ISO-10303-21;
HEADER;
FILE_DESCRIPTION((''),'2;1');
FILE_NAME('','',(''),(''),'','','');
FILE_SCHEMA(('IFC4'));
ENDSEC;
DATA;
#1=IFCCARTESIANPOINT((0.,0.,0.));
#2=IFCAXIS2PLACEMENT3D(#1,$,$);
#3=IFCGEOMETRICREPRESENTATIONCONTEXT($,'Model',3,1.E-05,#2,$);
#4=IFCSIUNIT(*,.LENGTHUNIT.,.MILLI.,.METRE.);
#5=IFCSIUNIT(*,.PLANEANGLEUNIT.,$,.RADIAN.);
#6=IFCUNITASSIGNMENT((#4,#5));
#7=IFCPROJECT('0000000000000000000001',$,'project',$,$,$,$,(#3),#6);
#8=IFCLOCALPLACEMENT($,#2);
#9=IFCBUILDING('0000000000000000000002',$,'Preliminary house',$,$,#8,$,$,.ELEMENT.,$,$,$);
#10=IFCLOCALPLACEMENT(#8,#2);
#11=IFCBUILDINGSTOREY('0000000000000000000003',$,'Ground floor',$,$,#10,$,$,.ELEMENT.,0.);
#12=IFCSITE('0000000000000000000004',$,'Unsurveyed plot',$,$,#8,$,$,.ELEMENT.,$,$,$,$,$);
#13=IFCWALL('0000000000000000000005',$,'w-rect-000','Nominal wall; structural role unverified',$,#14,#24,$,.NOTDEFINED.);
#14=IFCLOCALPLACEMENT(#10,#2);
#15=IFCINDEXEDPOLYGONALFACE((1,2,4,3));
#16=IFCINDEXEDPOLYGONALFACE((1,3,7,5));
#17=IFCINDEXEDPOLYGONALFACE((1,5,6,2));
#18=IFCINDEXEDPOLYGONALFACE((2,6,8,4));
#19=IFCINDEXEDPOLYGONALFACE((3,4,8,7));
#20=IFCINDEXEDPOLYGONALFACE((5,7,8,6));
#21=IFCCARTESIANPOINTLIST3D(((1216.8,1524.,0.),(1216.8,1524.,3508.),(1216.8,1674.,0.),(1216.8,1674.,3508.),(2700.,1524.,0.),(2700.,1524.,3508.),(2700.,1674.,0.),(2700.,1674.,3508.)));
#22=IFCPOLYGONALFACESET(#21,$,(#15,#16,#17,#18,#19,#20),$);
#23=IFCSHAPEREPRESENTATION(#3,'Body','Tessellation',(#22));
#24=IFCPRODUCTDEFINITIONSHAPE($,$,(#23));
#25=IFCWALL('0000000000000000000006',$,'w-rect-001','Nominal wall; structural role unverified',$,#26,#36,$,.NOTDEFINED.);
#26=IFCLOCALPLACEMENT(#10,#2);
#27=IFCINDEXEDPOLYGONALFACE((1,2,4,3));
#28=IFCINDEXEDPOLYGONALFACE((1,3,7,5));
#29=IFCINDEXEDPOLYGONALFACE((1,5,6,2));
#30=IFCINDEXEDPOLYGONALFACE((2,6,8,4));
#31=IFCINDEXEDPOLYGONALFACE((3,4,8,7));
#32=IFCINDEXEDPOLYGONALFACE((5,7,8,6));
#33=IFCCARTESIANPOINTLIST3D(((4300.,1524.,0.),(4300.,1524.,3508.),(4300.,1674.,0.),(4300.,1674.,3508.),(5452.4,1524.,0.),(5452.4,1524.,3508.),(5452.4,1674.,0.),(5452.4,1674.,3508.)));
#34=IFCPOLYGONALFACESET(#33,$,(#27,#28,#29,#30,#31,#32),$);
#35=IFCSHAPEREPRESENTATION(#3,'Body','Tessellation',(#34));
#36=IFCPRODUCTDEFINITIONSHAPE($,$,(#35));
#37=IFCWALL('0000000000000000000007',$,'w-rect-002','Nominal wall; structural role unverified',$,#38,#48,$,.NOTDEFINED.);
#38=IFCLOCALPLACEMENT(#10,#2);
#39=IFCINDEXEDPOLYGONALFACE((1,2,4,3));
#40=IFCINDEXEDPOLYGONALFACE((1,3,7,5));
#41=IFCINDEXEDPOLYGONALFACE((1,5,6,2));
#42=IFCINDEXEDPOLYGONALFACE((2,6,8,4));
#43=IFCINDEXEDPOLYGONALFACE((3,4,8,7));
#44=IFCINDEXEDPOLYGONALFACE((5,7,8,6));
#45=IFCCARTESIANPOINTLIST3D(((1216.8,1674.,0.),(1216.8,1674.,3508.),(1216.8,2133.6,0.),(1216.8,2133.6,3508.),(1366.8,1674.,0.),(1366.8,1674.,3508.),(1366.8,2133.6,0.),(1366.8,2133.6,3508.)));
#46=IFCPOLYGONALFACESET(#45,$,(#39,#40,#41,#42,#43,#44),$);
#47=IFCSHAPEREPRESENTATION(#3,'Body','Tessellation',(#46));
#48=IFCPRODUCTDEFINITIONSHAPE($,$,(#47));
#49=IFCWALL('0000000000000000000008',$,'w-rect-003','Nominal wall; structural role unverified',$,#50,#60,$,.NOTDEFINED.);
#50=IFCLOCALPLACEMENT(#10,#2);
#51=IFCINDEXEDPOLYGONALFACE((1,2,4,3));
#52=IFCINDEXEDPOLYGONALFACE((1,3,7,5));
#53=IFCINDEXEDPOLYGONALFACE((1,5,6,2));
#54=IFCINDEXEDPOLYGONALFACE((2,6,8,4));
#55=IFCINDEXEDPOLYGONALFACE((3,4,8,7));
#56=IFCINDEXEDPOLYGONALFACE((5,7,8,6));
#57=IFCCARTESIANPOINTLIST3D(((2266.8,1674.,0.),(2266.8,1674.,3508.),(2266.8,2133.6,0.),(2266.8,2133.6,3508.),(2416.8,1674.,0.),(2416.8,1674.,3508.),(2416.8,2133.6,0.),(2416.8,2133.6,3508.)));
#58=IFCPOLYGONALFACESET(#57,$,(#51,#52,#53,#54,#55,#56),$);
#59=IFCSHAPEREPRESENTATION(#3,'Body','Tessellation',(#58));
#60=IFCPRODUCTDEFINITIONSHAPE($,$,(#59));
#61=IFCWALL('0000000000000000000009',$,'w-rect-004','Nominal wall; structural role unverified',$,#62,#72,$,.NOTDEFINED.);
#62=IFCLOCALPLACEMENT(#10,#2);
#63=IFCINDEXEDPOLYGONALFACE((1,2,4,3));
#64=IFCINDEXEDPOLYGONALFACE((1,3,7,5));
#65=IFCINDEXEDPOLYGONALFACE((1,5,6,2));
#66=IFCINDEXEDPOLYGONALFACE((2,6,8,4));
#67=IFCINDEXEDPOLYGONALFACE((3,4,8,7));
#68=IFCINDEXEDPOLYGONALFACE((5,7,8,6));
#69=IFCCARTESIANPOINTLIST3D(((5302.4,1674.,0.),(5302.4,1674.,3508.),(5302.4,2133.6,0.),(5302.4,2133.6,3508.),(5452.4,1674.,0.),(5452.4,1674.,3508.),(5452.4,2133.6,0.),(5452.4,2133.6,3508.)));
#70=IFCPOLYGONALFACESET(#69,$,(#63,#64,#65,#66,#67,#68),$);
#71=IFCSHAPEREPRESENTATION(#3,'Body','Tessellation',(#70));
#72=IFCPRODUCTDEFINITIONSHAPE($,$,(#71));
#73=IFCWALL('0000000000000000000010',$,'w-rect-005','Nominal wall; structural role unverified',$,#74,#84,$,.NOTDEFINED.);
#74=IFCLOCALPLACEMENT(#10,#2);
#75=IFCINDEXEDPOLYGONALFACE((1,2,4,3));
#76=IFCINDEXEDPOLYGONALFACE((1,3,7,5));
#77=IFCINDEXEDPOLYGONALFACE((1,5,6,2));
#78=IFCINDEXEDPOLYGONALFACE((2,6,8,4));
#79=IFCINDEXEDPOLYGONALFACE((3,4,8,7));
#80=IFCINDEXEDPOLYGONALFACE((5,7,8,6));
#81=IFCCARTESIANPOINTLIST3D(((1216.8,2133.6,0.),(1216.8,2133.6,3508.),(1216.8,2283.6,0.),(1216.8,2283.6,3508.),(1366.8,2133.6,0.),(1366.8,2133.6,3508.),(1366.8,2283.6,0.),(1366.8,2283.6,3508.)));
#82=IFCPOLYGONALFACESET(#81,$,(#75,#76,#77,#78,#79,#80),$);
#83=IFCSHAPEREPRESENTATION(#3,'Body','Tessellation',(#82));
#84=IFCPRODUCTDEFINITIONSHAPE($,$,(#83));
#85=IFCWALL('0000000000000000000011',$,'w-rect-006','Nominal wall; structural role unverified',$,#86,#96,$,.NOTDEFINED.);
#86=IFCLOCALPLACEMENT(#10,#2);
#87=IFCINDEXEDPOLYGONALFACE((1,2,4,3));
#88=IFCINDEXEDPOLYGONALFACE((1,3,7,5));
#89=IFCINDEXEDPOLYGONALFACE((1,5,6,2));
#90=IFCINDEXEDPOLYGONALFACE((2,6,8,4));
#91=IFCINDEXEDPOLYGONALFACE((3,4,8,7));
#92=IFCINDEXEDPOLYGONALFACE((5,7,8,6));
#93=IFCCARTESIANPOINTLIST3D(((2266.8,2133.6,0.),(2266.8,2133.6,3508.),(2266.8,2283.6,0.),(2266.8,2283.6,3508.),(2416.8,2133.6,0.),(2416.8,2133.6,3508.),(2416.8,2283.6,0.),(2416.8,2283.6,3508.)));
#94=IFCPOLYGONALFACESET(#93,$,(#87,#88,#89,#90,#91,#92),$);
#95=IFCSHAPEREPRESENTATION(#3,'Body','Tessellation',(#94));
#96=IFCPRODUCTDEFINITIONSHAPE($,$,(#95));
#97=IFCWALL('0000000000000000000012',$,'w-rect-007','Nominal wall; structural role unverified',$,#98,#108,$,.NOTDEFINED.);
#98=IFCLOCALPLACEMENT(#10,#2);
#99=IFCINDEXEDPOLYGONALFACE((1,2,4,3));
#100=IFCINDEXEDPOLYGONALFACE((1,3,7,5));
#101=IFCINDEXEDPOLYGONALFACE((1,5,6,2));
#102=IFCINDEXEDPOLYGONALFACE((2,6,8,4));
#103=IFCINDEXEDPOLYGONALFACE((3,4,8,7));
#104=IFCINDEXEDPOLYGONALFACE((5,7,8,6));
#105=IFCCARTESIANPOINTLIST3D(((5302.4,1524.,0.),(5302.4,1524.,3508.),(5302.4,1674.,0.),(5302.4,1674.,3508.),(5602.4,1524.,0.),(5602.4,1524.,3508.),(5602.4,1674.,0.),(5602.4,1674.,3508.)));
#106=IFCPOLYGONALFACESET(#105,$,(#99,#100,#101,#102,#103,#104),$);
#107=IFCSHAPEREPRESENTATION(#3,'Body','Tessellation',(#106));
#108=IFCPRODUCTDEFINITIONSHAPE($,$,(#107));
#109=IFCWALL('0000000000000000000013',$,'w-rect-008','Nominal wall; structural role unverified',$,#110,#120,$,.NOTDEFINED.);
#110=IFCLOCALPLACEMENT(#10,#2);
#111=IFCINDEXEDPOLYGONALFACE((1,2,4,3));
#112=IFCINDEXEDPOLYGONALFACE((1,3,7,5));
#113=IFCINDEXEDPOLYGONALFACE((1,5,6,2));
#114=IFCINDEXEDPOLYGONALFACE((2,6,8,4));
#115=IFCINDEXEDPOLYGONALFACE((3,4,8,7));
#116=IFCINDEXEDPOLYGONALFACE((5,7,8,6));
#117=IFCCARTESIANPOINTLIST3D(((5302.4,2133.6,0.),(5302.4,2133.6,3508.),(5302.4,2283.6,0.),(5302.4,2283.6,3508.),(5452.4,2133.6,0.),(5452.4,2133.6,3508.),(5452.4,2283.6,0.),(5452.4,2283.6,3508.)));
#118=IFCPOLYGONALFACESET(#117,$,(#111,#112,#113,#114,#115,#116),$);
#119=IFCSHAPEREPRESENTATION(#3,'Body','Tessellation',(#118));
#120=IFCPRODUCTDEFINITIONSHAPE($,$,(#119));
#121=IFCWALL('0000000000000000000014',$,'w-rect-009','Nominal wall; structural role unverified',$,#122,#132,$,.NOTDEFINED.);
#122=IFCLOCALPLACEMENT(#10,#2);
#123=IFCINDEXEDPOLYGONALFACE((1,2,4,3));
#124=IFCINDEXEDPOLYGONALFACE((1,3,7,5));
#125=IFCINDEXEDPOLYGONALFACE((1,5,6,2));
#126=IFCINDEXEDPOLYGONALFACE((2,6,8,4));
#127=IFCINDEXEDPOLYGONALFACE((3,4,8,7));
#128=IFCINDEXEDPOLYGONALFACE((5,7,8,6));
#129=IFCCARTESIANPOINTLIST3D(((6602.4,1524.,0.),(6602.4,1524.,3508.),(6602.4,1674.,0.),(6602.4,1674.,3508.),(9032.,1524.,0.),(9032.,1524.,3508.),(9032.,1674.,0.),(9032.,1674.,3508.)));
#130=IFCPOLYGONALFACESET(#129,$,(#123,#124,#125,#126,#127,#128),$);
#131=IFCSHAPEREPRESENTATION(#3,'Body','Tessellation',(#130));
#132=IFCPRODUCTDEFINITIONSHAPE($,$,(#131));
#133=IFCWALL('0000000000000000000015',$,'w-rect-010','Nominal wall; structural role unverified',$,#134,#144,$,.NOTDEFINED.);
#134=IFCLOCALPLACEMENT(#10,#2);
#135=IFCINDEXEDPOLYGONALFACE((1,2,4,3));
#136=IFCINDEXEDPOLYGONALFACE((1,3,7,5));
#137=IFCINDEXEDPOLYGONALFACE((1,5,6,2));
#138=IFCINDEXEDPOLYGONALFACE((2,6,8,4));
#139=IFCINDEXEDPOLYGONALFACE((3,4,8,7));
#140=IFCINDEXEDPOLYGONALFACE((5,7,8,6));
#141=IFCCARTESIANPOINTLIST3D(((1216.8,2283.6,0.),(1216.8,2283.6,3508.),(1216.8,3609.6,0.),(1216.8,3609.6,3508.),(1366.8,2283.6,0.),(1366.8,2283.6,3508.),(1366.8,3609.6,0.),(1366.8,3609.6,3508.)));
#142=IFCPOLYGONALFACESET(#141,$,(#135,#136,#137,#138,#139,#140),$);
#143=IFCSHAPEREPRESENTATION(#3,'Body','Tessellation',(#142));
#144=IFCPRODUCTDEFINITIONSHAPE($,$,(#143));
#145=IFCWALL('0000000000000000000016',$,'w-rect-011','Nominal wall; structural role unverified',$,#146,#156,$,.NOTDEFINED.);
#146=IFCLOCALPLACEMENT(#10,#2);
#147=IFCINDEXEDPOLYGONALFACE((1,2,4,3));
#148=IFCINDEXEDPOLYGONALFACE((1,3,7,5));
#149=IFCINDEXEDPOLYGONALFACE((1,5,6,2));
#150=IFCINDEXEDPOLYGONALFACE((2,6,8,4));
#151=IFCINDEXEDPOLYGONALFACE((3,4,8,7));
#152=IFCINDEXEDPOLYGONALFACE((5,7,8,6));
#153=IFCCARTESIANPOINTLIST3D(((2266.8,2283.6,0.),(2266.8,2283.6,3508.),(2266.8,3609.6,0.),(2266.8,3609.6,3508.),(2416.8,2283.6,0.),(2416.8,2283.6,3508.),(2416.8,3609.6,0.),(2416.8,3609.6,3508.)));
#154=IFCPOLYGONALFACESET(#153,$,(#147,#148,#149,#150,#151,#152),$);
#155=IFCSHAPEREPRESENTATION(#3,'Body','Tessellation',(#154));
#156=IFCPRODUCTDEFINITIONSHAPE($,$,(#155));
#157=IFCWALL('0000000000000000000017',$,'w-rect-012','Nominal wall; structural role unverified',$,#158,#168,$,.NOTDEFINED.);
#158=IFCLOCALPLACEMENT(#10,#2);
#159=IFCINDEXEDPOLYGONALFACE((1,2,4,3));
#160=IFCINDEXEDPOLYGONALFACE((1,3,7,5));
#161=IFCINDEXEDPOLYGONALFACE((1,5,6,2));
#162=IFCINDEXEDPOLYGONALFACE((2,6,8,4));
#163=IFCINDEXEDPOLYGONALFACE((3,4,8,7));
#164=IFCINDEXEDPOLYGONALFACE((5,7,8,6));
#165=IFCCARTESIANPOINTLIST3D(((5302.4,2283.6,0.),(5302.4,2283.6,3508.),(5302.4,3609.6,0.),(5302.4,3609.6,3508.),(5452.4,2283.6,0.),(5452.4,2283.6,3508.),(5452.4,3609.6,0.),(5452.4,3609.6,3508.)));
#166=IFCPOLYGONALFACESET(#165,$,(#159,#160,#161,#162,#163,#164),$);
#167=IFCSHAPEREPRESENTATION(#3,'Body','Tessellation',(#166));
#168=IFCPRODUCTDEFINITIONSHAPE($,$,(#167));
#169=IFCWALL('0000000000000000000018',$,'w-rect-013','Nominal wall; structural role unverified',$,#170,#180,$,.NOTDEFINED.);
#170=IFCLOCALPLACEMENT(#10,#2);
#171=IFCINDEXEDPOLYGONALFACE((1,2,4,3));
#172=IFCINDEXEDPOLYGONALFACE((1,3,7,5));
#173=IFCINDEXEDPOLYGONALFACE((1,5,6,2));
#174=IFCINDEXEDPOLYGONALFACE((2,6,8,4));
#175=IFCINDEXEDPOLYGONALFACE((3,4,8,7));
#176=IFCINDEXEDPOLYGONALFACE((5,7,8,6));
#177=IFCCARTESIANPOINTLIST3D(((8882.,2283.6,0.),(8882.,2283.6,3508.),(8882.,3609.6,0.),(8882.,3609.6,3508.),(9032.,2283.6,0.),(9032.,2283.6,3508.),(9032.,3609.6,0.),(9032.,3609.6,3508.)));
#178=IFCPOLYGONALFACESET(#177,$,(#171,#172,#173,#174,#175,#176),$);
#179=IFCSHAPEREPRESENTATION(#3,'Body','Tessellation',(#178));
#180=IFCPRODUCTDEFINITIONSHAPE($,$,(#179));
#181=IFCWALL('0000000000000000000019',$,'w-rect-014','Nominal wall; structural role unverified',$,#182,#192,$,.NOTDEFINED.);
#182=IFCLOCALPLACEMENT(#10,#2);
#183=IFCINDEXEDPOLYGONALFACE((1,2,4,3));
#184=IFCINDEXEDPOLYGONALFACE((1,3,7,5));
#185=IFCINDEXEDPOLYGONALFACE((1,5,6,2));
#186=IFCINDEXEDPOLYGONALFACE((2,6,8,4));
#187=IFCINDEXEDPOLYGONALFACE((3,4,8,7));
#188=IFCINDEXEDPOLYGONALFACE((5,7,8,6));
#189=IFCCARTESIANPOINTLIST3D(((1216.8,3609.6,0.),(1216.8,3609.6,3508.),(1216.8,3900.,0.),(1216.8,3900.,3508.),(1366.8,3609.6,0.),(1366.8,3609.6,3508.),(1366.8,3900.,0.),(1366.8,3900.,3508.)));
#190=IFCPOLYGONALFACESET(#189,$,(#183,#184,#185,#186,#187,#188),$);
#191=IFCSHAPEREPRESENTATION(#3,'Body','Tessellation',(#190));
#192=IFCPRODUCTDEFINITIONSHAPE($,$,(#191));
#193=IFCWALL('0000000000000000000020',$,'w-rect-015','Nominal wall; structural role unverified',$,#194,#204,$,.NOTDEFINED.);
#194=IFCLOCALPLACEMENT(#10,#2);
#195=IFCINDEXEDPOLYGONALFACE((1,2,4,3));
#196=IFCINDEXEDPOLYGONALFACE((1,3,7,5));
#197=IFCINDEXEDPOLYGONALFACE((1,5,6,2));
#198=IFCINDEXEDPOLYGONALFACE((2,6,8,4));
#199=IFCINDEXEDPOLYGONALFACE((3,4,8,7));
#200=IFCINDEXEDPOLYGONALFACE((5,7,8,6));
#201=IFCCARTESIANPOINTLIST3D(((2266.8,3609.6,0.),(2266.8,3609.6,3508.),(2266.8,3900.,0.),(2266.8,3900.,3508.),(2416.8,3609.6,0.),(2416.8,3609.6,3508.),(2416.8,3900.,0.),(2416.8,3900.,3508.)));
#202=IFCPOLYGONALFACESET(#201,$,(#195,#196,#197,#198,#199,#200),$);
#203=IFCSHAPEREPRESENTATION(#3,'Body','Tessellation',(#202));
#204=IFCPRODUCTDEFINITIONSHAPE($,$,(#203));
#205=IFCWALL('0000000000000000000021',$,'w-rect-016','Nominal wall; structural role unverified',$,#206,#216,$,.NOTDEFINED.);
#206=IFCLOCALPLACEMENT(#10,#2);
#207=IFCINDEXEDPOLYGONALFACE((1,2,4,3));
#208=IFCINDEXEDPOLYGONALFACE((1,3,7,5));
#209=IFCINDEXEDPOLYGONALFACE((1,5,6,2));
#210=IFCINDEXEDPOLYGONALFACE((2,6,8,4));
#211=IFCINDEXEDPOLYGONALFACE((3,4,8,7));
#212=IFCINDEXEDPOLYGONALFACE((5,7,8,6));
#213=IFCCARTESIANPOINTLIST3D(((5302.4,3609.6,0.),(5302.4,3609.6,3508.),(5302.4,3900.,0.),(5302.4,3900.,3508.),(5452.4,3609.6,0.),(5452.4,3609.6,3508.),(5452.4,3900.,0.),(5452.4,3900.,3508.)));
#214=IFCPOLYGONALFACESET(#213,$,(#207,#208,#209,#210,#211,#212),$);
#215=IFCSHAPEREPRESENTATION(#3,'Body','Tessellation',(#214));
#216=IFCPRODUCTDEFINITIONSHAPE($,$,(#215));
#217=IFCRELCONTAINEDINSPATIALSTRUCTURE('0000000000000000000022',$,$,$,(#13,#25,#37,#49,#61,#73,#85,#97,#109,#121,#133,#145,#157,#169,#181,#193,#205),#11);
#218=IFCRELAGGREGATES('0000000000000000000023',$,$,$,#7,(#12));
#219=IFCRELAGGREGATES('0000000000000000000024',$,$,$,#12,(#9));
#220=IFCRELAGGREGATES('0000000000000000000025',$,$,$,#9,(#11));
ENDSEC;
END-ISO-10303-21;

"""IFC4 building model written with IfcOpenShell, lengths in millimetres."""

from ifc_helpers import new_model, si_unit, origin, place, context, project, spatial, polyline, outline, extrude, element, save


model = new_model("IFC4")

# Units and contexts
model_context = context("Model", 3, precision=1e-05, world=origin())
ifc_project = project(units=[si_unit("LENGTHUNIT", "METRE", prefix="MILLI"), si_unit("PLANEANGLEUNIT", "RADIAN")], contexts=[model_context])

# Site, building, storey
placement_1 = place(None, origin())
site = spatial("IfcSite", under=ifc_project, at=placement_1, Name="Unsurveyed plot", CompositionType="ELEMENT")
building = spatial("IfcBuilding", under=site, at=placement_1, Name="Preliminary house", CompositionType="ELEMENT")
placement_2 = place(placement_1, origin())
storey = spatial("IfcBuildingStorey", under=building, at=placement_2, Name="Ground floor", CompositionType="ELEMENT", Elevation=0.0)

# Walls
element("IfcWall", 1, at=placement_2, inside=storey, Name="w-rect-000", Description="Nominal wall; structural role unverified", PredefinedType="NOTDEFINED", context=model_context, shape_type="SweptSolid", body=[
    extrude(outline(polyline([(1216.8, 1524.0), (2700.0, 1524.0), (2700.0, 1674.0), (1216.8, 1674.0), (1216.8, 1524.0)])), origin(), (0.0, 0.0, 1.0), 3508.0),
])
element("IfcWall", 2, at=placement_2, inside=storey, Name="w-rect-001", Description="Nominal wall; structural role unverified", PredefinedType="NOTDEFINED", context=model_context, shape_type="SweptSolid", body=[
    extrude(outline(polyline([(4300.0, 1524.0), (5452.4, 1524.0), (5452.4, 1674.0), (4300.0, 1674.0), (4300.0, 1524.0)])), origin(), (0.0, 0.0, 1.0), 3508.0),
])
element("IfcWall", 3, at=placement_2, inside=storey, Name="w-rect-002", Description="Nominal wall; structural role unverified", PredefinedType="NOTDEFINED", context=model_context, shape_type="SweptSolid", body=[
    extrude(outline(polyline([(1216.8, 1674.0), (1366.8, 1674.0), (1366.8, 2133.6), (1216.8, 2133.6), (1216.8, 1674.0)])), origin(), (0.0, 0.0, 1.0), 3508.0),
])
element("IfcWall", 4, at=placement_2, inside=storey, Name="w-rect-003", Description="Nominal wall; structural role unverified", PredefinedType="NOTDEFINED", context=model_context, shape_type="SweptSolid", body=[
    extrude(outline(polyline([(2266.8, 1674.0), (2416.8, 1674.0), (2416.8, 2133.6), (2266.8, 2133.6), (2266.8, 1674.0)])), origin(), (0.0, 0.0, 1.0), 3508.0),
])
element("IfcWall", 5, at=placement_2, inside=storey, Name="w-rect-004", Description="Nominal wall; structural role unverified", PredefinedType="NOTDEFINED", context=model_context, shape_type="SweptSolid", body=[
    extrude(outline(polyline([(5302.4, 1674.0), (5452.4, 1674.0), (5452.4, 2133.6), (5302.4, 2133.6), (5302.4, 1674.0)])), origin(), (0.0, 0.0, 1.0), 3508.0),
])
element("IfcWall", 6, at=placement_2, inside=storey, Name="w-rect-005", Description="Nominal wall; structural role unverified", PredefinedType="NOTDEFINED", context=model_context, shape_type="SweptSolid", body=[
    extrude(outline(polyline([(1216.8, 2133.6), (1366.8, 2133.6), (1366.8, 2283.6), (1216.8, 2283.6), (1216.8, 2133.6)])), origin(), (0.0, 0.0, 1.0), 3508.0),
])
element("IfcWall", 7, at=placement_2, inside=storey, Name="w-rect-006", Description="Nominal wall; structural role unverified", PredefinedType="NOTDEFINED", context=model_context, shape_type="SweptSolid", body=[
    extrude(outline(polyline([(2266.8, 2133.6), (2416.8, 2133.6), (2416.8, 2283.6), (2266.8, 2283.6), (2266.8, 2133.6)])), origin(), (0.0, 0.0, 1.0), 3508.0),
])
element("IfcWall", 8, at=placement_2, inside=storey, Name="w-rect-007", Description="Nominal wall; structural role unverified", PredefinedType="NOTDEFINED", context=model_context, shape_type="SweptSolid", body=[
    extrude(outline(polyline([(5302.4, 1524.0), (5602.4, 1524.0), (5602.4, 1674.0), (5302.4, 1674.0), (5302.4, 1524.0)])), origin(), (0.0, 0.0, 1.0), 3508.0),
])
element("IfcWall", 9, at=placement_2, inside=storey, Name="w-rect-008", Description="Nominal wall; structural role unverified", PredefinedType="NOTDEFINED", context=model_context, shape_type="SweptSolid", body=[
    extrude(outline(polyline([(5302.4, 2133.6), (5452.4, 2133.6), (5452.4, 2283.6), (5302.4, 2283.6), (5302.4, 2133.6)])), origin(), (0.0, 0.0, 1.0), 3508.0),
])
element("IfcWall", 10, at=placement_2, inside=storey, Name="w-rect-009", Description="Nominal wall; structural role unverified", PredefinedType="NOTDEFINED", context=model_context, shape_type="SweptSolid", body=[
    extrude(outline(polyline([(6602.4, 1524.0), (9032.0, 1524.0), (9032.0, 1674.0), (6602.4, 1674.0), (6602.4, 1524.0)])), origin(), (0.0, 0.0, 1.0), 3508.0),
])
element("IfcWall", 11, at=placement_2, inside=storey, Name="w-rect-010", Description="Nominal wall; structural role unverified", PredefinedType="NOTDEFINED", context=model_context, shape_type="SweptSolid", body=[
    extrude(outline(polyline([(1216.8, 2283.6), (1366.8, 2283.6), (1366.8, 3609.6), (1216.8, 3609.6), (1216.8, 2283.6)])), origin(), (0.0, 0.0, 1.0), 3508.0),
])
element("IfcWall", 12, at=placement_2, inside=storey, Name="w-rect-011", Description="Nominal wall; structural role unverified", PredefinedType="NOTDEFINED", context=model_context, shape_type="SweptSolid", body=[
    extrude(outline(polyline([(2266.8, 2283.6), (2416.8, 2283.6), (2416.8, 3609.6), (2266.8, 3609.6), (2266.8, 2283.6)])), origin(), (0.0, 0.0, 1.0), 3508.0),
])
element("IfcWall", 13, at=placement_2, inside=storey, Name="w-rect-012", Description="Nominal wall; structural role unverified", PredefinedType="NOTDEFINED", context=model_context, shape_type="SweptSolid", body=[
    extrude(outline(polyline([(5302.4, 2283.6), (5452.4, 2283.6), (5452.4, 3609.6), (5302.4, 3609.6), (5302.4, 2283.6)])), origin(), (0.0, 0.0, 1.0), 3508.0),
])
element("IfcWall", 14, at=placement_2, inside=storey, Name="w-rect-013", Description="Nominal wall; structural role unverified", PredefinedType="NOTDEFINED", context=model_context, shape_type="SweptSolid", body=[
    extrude(outline(polyline([(8882.0, 2283.6), (9032.0, 2283.6), (9032.0, 3609.6), (8882.0, 3609.6), (8882.0, 2283.6)])), origin(), (0.0, 0.0, 1.0), 3508.0),
])
element("IfcWall", 15, at=placement_2, inside=storey, Name="w-rect-014", Description="Nominal wall; structural role unverified", PredefinedType="NOTDEFINED", context=model_context, shape_type="SweptSolid", body=[
    extrude(outline(polyline([(1216.8, 3609.6), (1366.8, 3609.6), (1366.8, 3900.0), (1216.8, 3900.0), (1216.8, 3609.6)])), origin(), (0.0, 0.0, 1.0), 3508.0),
])
element("IfcWall", 16, at=placement_2, inside=storey, Name="w-rect-015", Description="Nominal wall; structural role unverified", PredefinedType="NOTDEFINED", context=model_context, shape_type="SweptSolid", body=[
    extrude(outline(polyline([(2266.8, 3609.6), (2416.8, 3609.6), (2416.8, 3900.0), (2266.8, 3900.0), (2266.8, 3609.6)])), origin(), (0.0, 0.0, 1.0), 3508.0),
])
element("IfcWall", 17, at=placement_2, inside=storey, Name="w-rect-016", Description="Nominal wall; structural role unverified", PredefinedType="NOTDEFINED", context=model_context, shape_type="SweptSolid", body=[
    extrude(outline(polyline([(5302.4, 3609.6), (5452.4, 3609.6), (5452.4, 3900.0), (5302.4, 3900.0), (5302.4, 3609.6)])), origin(), (0.0, 0.0, 1.0), 3508.0),
])

save(model, "model.ifc")
